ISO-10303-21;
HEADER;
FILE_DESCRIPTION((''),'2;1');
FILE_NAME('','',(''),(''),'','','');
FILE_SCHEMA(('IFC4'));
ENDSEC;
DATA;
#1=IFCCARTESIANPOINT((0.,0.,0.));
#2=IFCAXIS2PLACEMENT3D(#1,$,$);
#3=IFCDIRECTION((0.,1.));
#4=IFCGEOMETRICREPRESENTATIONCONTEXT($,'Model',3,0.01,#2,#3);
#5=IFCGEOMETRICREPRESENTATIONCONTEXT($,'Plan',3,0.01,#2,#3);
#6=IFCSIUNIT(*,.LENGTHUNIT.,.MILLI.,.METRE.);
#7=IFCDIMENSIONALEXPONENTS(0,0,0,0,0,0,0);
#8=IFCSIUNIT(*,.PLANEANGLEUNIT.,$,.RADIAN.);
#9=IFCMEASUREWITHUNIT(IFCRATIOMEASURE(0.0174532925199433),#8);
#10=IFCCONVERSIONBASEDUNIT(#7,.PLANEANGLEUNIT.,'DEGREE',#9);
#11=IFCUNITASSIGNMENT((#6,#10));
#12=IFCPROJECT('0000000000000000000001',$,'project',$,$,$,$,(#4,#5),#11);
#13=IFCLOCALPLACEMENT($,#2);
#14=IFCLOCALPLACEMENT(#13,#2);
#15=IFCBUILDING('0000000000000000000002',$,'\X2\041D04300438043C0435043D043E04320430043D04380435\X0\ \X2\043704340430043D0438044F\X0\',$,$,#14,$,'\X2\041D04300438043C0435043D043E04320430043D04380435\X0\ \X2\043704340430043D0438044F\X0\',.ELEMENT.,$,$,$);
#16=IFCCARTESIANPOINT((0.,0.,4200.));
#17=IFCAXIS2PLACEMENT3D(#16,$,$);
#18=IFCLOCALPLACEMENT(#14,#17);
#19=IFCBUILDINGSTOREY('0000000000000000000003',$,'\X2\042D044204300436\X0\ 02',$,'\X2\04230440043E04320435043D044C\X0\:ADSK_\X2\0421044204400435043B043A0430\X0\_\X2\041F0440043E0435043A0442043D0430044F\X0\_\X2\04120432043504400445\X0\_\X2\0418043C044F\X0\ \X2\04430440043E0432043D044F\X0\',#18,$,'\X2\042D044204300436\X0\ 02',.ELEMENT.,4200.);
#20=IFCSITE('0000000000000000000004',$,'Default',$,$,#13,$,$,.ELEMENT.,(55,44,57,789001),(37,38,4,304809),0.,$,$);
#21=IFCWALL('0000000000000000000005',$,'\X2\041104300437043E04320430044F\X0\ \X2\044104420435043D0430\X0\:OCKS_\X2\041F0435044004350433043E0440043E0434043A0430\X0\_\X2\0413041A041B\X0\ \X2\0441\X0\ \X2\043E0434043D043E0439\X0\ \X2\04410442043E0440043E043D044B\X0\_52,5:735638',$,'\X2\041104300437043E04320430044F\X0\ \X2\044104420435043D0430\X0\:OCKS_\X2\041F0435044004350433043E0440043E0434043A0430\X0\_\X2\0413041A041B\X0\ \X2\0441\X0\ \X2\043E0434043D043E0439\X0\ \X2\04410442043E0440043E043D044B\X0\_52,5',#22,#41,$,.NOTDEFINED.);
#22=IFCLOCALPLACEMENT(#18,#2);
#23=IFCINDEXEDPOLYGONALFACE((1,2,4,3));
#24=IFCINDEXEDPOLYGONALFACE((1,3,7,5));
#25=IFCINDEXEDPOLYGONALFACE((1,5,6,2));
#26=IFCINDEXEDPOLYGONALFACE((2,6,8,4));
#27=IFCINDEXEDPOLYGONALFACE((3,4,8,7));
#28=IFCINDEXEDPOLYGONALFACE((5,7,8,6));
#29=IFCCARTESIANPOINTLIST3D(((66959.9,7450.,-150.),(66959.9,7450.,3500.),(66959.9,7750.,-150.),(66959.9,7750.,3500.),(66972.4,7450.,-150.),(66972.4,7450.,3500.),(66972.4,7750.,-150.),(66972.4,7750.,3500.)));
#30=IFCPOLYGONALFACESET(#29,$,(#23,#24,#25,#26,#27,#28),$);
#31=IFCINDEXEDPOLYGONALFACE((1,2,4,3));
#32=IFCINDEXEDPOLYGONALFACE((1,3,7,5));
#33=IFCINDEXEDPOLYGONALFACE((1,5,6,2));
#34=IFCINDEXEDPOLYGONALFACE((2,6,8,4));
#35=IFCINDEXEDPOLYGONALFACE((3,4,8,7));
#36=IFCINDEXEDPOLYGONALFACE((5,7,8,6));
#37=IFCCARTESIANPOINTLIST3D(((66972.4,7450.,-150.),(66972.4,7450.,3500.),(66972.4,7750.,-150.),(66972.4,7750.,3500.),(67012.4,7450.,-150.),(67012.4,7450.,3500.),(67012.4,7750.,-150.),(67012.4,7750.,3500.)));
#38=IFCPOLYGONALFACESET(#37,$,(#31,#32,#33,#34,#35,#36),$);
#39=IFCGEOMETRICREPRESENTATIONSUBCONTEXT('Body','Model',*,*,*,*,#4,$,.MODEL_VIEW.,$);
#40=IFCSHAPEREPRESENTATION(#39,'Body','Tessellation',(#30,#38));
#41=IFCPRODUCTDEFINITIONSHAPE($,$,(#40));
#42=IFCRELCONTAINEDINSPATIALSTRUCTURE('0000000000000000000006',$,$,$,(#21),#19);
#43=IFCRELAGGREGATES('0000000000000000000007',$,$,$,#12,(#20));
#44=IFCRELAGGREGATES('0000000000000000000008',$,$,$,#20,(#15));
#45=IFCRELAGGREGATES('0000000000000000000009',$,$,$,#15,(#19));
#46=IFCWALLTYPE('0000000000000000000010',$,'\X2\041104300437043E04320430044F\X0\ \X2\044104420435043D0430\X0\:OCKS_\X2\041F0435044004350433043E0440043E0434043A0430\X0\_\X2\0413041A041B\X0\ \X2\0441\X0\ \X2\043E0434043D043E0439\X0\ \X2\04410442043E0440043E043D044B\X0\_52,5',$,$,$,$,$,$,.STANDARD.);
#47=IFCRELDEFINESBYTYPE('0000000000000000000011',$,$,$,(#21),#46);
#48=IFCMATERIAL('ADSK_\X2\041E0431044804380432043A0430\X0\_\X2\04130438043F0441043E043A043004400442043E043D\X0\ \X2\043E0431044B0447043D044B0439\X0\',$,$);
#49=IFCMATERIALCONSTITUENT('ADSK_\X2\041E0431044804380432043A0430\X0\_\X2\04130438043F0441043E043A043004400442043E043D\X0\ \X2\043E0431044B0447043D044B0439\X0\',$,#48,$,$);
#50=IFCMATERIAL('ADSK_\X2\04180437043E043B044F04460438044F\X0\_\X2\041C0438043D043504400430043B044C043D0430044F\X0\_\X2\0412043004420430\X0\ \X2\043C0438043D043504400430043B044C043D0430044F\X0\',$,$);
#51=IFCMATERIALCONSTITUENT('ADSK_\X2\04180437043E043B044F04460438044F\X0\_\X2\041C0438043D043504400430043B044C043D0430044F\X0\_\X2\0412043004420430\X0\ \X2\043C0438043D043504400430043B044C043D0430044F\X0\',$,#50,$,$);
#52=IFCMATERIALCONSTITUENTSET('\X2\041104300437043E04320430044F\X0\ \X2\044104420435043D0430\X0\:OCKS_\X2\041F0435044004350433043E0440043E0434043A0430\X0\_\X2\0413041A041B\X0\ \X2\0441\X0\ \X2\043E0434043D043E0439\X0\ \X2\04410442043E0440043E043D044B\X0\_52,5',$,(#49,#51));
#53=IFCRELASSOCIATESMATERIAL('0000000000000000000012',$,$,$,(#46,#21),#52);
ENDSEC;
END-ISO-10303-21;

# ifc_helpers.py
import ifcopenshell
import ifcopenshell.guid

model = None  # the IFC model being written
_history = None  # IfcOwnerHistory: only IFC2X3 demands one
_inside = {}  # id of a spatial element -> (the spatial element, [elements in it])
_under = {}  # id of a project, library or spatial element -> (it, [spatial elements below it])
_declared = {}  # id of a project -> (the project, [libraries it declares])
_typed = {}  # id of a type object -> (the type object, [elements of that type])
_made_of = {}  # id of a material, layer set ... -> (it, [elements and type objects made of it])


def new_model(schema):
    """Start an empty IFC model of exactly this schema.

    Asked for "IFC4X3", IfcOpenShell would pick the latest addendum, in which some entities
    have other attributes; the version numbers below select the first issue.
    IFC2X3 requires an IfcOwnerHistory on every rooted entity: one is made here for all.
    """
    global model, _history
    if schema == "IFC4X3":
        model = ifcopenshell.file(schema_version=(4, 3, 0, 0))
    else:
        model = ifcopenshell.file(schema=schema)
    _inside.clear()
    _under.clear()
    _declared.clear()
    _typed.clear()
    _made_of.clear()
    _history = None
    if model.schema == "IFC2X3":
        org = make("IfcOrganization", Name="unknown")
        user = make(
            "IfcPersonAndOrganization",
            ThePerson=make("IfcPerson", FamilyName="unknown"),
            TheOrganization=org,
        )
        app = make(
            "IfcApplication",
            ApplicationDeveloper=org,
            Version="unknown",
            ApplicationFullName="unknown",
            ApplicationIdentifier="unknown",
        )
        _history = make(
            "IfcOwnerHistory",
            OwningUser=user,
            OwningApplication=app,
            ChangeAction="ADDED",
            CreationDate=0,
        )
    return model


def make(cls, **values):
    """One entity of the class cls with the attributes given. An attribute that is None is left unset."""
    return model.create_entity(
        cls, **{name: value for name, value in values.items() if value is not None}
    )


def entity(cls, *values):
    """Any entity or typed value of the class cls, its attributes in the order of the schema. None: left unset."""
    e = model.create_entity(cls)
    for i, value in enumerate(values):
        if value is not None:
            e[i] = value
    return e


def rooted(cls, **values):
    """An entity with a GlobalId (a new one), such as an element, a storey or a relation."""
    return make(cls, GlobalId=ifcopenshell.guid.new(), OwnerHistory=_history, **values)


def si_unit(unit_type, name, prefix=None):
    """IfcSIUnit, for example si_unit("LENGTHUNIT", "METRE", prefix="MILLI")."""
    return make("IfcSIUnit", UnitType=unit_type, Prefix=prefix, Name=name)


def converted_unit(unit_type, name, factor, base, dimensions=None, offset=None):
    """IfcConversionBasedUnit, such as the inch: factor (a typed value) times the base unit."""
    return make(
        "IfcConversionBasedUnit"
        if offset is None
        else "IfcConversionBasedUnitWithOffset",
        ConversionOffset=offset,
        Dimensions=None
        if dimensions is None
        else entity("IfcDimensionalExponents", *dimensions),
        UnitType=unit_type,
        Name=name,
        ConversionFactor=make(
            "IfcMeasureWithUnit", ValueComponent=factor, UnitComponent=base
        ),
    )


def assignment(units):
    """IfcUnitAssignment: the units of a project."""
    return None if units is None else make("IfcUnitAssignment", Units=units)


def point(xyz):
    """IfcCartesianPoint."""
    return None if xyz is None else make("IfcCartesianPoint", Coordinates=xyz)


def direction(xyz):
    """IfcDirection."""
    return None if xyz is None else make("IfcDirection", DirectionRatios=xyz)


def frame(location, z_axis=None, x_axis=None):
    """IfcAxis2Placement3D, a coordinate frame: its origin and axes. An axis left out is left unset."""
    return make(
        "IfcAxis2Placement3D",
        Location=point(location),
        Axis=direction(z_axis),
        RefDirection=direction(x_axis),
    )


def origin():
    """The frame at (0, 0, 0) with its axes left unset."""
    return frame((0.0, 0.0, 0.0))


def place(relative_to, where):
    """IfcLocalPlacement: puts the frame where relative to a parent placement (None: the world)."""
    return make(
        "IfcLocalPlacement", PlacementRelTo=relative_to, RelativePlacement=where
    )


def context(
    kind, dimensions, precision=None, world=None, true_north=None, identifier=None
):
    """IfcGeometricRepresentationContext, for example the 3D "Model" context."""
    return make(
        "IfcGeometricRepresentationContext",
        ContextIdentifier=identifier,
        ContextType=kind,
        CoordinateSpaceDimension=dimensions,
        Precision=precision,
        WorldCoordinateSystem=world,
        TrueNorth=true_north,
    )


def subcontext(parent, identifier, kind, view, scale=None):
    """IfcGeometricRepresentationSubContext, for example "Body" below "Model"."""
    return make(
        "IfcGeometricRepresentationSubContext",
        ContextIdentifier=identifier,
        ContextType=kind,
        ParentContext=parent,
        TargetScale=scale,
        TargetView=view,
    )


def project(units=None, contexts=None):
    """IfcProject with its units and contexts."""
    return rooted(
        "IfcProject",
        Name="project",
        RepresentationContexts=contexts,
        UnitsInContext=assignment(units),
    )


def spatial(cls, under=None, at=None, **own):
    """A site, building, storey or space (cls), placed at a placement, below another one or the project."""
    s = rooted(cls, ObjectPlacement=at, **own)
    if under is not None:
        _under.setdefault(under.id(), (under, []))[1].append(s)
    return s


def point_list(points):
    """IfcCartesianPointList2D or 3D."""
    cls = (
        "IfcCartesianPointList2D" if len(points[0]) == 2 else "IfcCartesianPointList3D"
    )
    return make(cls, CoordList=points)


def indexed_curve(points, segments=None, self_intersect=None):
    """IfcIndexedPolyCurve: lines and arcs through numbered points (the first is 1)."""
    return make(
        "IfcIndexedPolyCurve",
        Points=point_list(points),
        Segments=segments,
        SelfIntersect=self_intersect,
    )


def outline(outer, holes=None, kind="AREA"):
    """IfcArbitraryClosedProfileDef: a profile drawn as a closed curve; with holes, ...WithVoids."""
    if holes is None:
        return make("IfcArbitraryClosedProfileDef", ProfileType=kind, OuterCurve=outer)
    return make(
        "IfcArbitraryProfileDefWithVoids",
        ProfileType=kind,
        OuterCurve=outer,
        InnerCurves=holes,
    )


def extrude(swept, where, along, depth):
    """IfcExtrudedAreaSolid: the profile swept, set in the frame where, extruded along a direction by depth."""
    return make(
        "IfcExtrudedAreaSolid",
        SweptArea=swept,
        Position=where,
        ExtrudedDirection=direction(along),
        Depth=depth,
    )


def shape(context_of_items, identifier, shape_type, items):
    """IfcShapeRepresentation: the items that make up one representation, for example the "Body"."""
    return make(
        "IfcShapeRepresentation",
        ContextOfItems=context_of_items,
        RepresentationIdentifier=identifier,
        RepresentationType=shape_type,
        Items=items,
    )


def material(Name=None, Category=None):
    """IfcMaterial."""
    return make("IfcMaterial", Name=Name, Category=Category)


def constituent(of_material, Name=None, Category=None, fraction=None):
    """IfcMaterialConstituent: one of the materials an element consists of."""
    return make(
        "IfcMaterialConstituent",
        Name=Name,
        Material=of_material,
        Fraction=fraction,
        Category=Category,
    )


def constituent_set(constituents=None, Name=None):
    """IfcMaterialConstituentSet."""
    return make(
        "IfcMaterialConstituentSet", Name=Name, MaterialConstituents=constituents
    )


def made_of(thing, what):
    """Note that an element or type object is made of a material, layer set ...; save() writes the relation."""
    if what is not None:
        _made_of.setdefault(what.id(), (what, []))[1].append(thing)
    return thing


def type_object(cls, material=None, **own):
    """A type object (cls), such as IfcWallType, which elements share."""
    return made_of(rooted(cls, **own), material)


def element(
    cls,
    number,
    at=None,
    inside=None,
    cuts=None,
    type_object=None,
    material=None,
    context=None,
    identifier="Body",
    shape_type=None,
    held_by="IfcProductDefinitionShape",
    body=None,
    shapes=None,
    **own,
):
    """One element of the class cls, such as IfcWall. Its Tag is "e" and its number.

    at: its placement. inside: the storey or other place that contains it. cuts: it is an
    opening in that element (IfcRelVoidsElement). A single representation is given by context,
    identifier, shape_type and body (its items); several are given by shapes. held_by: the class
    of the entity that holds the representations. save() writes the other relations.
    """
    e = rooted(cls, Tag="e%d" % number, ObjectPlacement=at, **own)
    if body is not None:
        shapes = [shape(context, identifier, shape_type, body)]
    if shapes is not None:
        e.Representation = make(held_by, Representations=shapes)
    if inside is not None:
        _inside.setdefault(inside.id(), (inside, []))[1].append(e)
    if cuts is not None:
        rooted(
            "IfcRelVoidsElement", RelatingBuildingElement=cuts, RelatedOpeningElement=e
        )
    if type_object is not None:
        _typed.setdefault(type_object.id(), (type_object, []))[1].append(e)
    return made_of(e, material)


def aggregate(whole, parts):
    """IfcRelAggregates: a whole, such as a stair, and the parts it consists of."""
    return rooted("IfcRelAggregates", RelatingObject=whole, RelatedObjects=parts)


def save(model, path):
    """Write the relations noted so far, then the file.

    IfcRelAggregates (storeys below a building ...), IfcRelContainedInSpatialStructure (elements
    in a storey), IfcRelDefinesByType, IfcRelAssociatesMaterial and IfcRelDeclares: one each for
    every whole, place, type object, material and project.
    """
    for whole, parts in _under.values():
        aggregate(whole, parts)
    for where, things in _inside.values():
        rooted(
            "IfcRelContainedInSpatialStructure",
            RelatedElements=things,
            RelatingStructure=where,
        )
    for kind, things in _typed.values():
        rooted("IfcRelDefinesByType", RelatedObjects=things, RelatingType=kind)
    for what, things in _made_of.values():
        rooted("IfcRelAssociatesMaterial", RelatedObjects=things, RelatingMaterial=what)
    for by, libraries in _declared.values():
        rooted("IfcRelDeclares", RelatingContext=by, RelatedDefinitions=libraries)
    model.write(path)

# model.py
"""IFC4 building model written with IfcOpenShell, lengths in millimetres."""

from ifc_helpers import new_model, entity, si_unit, converted_unit, direction, frame, origin, place, context, subcontext, project, spatial, indexed_curve, outline, extrude, material, constituent, constituent_set, type_object, element, save


model = new_model("IFC4")

# Units and contexts
model_context = context("Model", 3, precision=0.01, world=origin(), true_north=direction((0.0, 1.0)))
plan_context = context("Plan", 3, precision=0.01, world=origin(), true_north=direction((0.0, 1.0)))
body_context = subcontext(model_context, "Body", "Model", "MODEL_VIEW")
ifc_project = project(units=[si_unit("LENGTHUNIT", "METRE", prefix="MILLI"), converted_unit("PLANEANGLEUNIT", "DEGREE", entity("IfcRatioMeasure", 0.0174532925199433), si_unit("PLANEANGLEUNIT", "RADIAN"), dimensions=[0, 0, 0, 0, 0, 0, 0])], contexts=[model_context, plan_context])

# Site, building, storey
site_placement = place(None, frame((0.0, 0.0, 0.0)))
site = spatial("IfcSite", under=ifc_project, at=site_placement, Name="Default", CompositionType="ELEMENT", RefLatitude=(55, 44, 57, 789001), RefLongitude=(37, 38, 4, 304809), RefElevation=0.0)
building_placement = place(site_placement, origin())
building = spatial("IfcBuilding", under=site, at=building_placement, Name="Наименование здания", LongName="Наименование здания", CompositionType="ELEMENT")
storey_placement = place(building_placement, frame((0.0, 0.0, 4200.0)))
storey = spatial("IfcBuildingStorey", under=building, at=storey_placement, Name="Этаж 02", ObjectType="Уровень:ADSK_Стрелка_Проектная_Вверх_Имя уровня", LongName="Этаж 02", CompositionType="ELEMENT", Elevation=4200.0)

# Shared definitions
ifc_material_1 = material(Name="ADSK_Обшивка_Гипсокартон обычный")
ifc_material_2 = material(Name="ADSK_Изоляция_Минеральная_Вата минеральная")

# Wall
ifc_constituent_1 = constituent(ifc_material_1, Name="ADSK_Обшивка_Гипсокартон обычный")
ifc_constituent_2 = constituent(ifc_material_2, Name="ADSK_Изоляция_Минеральная_Вата минеральная")
ifc_constituent_set_1 = constituent_set(constituents=[ifc_constituent_1, ifc_constituent_2], Name="Базовая стена:OCKS_Перегородка_ГКЛ с одной стороны_52,5")
wall_type_1 = type_object("IfcWallType", Name="Базовая стена:OCKS_Перегородка_ГКЛ с одной стороны_52,5", PredefinedType="STANDARD", material=ifc_constituent_set_1)
wall_1_placement = place(storey_placement, frame((66986.2, 7750.0, -150.0), z_axis=(0.0, 0.0, 1.0), x_axis=(0.0, -1.0, 0.0)))
element("IfcWall", 1, at=wall_1_placement, inside=storey, type_object=wall_type_1, material=ifc_constituent_set_1, Name="Базовая стена:OCKS_Перегородка_ГКЛ с одной стороны_52,5:735638", ObjectType="Базовая стена:OCKS_Перегородка_ГКЛ с одной стороны_52,5", PredefinedType="NOTDEFINED", context=body_context, shape_type="SweptSolid", body=[
    extrude(outline(indexed_curve([(-6.2, -150.0), (6.3, -150.0), (6.3, 150.0), (-6.2, 150.0), (-6.2, -150.0)], self_intersect=False)), frame((150.0, -20.0, 0.0), z_axis=(0.0, 0.0, 1.0), x_axis=(0.0, 1.0, 0.0)), (0.0, 0.0, 1.0), 3650.0),
    extrude(outline(indexed_curve([(-20.0, -150.0), (20.0, -150.0), (20.0, 150.0), (-20.0, 150.0), (-20.0, -150.0)], self_intersect=False)), frame((150.0, 6.2, 0.0), z_axis=(0.0, 0.0, 1.0), x_axis=(0.0, -1.0, 0.0)), (0.0, 0.0, 1.0), 3650.0),
])

save(model, "model.ifc")
